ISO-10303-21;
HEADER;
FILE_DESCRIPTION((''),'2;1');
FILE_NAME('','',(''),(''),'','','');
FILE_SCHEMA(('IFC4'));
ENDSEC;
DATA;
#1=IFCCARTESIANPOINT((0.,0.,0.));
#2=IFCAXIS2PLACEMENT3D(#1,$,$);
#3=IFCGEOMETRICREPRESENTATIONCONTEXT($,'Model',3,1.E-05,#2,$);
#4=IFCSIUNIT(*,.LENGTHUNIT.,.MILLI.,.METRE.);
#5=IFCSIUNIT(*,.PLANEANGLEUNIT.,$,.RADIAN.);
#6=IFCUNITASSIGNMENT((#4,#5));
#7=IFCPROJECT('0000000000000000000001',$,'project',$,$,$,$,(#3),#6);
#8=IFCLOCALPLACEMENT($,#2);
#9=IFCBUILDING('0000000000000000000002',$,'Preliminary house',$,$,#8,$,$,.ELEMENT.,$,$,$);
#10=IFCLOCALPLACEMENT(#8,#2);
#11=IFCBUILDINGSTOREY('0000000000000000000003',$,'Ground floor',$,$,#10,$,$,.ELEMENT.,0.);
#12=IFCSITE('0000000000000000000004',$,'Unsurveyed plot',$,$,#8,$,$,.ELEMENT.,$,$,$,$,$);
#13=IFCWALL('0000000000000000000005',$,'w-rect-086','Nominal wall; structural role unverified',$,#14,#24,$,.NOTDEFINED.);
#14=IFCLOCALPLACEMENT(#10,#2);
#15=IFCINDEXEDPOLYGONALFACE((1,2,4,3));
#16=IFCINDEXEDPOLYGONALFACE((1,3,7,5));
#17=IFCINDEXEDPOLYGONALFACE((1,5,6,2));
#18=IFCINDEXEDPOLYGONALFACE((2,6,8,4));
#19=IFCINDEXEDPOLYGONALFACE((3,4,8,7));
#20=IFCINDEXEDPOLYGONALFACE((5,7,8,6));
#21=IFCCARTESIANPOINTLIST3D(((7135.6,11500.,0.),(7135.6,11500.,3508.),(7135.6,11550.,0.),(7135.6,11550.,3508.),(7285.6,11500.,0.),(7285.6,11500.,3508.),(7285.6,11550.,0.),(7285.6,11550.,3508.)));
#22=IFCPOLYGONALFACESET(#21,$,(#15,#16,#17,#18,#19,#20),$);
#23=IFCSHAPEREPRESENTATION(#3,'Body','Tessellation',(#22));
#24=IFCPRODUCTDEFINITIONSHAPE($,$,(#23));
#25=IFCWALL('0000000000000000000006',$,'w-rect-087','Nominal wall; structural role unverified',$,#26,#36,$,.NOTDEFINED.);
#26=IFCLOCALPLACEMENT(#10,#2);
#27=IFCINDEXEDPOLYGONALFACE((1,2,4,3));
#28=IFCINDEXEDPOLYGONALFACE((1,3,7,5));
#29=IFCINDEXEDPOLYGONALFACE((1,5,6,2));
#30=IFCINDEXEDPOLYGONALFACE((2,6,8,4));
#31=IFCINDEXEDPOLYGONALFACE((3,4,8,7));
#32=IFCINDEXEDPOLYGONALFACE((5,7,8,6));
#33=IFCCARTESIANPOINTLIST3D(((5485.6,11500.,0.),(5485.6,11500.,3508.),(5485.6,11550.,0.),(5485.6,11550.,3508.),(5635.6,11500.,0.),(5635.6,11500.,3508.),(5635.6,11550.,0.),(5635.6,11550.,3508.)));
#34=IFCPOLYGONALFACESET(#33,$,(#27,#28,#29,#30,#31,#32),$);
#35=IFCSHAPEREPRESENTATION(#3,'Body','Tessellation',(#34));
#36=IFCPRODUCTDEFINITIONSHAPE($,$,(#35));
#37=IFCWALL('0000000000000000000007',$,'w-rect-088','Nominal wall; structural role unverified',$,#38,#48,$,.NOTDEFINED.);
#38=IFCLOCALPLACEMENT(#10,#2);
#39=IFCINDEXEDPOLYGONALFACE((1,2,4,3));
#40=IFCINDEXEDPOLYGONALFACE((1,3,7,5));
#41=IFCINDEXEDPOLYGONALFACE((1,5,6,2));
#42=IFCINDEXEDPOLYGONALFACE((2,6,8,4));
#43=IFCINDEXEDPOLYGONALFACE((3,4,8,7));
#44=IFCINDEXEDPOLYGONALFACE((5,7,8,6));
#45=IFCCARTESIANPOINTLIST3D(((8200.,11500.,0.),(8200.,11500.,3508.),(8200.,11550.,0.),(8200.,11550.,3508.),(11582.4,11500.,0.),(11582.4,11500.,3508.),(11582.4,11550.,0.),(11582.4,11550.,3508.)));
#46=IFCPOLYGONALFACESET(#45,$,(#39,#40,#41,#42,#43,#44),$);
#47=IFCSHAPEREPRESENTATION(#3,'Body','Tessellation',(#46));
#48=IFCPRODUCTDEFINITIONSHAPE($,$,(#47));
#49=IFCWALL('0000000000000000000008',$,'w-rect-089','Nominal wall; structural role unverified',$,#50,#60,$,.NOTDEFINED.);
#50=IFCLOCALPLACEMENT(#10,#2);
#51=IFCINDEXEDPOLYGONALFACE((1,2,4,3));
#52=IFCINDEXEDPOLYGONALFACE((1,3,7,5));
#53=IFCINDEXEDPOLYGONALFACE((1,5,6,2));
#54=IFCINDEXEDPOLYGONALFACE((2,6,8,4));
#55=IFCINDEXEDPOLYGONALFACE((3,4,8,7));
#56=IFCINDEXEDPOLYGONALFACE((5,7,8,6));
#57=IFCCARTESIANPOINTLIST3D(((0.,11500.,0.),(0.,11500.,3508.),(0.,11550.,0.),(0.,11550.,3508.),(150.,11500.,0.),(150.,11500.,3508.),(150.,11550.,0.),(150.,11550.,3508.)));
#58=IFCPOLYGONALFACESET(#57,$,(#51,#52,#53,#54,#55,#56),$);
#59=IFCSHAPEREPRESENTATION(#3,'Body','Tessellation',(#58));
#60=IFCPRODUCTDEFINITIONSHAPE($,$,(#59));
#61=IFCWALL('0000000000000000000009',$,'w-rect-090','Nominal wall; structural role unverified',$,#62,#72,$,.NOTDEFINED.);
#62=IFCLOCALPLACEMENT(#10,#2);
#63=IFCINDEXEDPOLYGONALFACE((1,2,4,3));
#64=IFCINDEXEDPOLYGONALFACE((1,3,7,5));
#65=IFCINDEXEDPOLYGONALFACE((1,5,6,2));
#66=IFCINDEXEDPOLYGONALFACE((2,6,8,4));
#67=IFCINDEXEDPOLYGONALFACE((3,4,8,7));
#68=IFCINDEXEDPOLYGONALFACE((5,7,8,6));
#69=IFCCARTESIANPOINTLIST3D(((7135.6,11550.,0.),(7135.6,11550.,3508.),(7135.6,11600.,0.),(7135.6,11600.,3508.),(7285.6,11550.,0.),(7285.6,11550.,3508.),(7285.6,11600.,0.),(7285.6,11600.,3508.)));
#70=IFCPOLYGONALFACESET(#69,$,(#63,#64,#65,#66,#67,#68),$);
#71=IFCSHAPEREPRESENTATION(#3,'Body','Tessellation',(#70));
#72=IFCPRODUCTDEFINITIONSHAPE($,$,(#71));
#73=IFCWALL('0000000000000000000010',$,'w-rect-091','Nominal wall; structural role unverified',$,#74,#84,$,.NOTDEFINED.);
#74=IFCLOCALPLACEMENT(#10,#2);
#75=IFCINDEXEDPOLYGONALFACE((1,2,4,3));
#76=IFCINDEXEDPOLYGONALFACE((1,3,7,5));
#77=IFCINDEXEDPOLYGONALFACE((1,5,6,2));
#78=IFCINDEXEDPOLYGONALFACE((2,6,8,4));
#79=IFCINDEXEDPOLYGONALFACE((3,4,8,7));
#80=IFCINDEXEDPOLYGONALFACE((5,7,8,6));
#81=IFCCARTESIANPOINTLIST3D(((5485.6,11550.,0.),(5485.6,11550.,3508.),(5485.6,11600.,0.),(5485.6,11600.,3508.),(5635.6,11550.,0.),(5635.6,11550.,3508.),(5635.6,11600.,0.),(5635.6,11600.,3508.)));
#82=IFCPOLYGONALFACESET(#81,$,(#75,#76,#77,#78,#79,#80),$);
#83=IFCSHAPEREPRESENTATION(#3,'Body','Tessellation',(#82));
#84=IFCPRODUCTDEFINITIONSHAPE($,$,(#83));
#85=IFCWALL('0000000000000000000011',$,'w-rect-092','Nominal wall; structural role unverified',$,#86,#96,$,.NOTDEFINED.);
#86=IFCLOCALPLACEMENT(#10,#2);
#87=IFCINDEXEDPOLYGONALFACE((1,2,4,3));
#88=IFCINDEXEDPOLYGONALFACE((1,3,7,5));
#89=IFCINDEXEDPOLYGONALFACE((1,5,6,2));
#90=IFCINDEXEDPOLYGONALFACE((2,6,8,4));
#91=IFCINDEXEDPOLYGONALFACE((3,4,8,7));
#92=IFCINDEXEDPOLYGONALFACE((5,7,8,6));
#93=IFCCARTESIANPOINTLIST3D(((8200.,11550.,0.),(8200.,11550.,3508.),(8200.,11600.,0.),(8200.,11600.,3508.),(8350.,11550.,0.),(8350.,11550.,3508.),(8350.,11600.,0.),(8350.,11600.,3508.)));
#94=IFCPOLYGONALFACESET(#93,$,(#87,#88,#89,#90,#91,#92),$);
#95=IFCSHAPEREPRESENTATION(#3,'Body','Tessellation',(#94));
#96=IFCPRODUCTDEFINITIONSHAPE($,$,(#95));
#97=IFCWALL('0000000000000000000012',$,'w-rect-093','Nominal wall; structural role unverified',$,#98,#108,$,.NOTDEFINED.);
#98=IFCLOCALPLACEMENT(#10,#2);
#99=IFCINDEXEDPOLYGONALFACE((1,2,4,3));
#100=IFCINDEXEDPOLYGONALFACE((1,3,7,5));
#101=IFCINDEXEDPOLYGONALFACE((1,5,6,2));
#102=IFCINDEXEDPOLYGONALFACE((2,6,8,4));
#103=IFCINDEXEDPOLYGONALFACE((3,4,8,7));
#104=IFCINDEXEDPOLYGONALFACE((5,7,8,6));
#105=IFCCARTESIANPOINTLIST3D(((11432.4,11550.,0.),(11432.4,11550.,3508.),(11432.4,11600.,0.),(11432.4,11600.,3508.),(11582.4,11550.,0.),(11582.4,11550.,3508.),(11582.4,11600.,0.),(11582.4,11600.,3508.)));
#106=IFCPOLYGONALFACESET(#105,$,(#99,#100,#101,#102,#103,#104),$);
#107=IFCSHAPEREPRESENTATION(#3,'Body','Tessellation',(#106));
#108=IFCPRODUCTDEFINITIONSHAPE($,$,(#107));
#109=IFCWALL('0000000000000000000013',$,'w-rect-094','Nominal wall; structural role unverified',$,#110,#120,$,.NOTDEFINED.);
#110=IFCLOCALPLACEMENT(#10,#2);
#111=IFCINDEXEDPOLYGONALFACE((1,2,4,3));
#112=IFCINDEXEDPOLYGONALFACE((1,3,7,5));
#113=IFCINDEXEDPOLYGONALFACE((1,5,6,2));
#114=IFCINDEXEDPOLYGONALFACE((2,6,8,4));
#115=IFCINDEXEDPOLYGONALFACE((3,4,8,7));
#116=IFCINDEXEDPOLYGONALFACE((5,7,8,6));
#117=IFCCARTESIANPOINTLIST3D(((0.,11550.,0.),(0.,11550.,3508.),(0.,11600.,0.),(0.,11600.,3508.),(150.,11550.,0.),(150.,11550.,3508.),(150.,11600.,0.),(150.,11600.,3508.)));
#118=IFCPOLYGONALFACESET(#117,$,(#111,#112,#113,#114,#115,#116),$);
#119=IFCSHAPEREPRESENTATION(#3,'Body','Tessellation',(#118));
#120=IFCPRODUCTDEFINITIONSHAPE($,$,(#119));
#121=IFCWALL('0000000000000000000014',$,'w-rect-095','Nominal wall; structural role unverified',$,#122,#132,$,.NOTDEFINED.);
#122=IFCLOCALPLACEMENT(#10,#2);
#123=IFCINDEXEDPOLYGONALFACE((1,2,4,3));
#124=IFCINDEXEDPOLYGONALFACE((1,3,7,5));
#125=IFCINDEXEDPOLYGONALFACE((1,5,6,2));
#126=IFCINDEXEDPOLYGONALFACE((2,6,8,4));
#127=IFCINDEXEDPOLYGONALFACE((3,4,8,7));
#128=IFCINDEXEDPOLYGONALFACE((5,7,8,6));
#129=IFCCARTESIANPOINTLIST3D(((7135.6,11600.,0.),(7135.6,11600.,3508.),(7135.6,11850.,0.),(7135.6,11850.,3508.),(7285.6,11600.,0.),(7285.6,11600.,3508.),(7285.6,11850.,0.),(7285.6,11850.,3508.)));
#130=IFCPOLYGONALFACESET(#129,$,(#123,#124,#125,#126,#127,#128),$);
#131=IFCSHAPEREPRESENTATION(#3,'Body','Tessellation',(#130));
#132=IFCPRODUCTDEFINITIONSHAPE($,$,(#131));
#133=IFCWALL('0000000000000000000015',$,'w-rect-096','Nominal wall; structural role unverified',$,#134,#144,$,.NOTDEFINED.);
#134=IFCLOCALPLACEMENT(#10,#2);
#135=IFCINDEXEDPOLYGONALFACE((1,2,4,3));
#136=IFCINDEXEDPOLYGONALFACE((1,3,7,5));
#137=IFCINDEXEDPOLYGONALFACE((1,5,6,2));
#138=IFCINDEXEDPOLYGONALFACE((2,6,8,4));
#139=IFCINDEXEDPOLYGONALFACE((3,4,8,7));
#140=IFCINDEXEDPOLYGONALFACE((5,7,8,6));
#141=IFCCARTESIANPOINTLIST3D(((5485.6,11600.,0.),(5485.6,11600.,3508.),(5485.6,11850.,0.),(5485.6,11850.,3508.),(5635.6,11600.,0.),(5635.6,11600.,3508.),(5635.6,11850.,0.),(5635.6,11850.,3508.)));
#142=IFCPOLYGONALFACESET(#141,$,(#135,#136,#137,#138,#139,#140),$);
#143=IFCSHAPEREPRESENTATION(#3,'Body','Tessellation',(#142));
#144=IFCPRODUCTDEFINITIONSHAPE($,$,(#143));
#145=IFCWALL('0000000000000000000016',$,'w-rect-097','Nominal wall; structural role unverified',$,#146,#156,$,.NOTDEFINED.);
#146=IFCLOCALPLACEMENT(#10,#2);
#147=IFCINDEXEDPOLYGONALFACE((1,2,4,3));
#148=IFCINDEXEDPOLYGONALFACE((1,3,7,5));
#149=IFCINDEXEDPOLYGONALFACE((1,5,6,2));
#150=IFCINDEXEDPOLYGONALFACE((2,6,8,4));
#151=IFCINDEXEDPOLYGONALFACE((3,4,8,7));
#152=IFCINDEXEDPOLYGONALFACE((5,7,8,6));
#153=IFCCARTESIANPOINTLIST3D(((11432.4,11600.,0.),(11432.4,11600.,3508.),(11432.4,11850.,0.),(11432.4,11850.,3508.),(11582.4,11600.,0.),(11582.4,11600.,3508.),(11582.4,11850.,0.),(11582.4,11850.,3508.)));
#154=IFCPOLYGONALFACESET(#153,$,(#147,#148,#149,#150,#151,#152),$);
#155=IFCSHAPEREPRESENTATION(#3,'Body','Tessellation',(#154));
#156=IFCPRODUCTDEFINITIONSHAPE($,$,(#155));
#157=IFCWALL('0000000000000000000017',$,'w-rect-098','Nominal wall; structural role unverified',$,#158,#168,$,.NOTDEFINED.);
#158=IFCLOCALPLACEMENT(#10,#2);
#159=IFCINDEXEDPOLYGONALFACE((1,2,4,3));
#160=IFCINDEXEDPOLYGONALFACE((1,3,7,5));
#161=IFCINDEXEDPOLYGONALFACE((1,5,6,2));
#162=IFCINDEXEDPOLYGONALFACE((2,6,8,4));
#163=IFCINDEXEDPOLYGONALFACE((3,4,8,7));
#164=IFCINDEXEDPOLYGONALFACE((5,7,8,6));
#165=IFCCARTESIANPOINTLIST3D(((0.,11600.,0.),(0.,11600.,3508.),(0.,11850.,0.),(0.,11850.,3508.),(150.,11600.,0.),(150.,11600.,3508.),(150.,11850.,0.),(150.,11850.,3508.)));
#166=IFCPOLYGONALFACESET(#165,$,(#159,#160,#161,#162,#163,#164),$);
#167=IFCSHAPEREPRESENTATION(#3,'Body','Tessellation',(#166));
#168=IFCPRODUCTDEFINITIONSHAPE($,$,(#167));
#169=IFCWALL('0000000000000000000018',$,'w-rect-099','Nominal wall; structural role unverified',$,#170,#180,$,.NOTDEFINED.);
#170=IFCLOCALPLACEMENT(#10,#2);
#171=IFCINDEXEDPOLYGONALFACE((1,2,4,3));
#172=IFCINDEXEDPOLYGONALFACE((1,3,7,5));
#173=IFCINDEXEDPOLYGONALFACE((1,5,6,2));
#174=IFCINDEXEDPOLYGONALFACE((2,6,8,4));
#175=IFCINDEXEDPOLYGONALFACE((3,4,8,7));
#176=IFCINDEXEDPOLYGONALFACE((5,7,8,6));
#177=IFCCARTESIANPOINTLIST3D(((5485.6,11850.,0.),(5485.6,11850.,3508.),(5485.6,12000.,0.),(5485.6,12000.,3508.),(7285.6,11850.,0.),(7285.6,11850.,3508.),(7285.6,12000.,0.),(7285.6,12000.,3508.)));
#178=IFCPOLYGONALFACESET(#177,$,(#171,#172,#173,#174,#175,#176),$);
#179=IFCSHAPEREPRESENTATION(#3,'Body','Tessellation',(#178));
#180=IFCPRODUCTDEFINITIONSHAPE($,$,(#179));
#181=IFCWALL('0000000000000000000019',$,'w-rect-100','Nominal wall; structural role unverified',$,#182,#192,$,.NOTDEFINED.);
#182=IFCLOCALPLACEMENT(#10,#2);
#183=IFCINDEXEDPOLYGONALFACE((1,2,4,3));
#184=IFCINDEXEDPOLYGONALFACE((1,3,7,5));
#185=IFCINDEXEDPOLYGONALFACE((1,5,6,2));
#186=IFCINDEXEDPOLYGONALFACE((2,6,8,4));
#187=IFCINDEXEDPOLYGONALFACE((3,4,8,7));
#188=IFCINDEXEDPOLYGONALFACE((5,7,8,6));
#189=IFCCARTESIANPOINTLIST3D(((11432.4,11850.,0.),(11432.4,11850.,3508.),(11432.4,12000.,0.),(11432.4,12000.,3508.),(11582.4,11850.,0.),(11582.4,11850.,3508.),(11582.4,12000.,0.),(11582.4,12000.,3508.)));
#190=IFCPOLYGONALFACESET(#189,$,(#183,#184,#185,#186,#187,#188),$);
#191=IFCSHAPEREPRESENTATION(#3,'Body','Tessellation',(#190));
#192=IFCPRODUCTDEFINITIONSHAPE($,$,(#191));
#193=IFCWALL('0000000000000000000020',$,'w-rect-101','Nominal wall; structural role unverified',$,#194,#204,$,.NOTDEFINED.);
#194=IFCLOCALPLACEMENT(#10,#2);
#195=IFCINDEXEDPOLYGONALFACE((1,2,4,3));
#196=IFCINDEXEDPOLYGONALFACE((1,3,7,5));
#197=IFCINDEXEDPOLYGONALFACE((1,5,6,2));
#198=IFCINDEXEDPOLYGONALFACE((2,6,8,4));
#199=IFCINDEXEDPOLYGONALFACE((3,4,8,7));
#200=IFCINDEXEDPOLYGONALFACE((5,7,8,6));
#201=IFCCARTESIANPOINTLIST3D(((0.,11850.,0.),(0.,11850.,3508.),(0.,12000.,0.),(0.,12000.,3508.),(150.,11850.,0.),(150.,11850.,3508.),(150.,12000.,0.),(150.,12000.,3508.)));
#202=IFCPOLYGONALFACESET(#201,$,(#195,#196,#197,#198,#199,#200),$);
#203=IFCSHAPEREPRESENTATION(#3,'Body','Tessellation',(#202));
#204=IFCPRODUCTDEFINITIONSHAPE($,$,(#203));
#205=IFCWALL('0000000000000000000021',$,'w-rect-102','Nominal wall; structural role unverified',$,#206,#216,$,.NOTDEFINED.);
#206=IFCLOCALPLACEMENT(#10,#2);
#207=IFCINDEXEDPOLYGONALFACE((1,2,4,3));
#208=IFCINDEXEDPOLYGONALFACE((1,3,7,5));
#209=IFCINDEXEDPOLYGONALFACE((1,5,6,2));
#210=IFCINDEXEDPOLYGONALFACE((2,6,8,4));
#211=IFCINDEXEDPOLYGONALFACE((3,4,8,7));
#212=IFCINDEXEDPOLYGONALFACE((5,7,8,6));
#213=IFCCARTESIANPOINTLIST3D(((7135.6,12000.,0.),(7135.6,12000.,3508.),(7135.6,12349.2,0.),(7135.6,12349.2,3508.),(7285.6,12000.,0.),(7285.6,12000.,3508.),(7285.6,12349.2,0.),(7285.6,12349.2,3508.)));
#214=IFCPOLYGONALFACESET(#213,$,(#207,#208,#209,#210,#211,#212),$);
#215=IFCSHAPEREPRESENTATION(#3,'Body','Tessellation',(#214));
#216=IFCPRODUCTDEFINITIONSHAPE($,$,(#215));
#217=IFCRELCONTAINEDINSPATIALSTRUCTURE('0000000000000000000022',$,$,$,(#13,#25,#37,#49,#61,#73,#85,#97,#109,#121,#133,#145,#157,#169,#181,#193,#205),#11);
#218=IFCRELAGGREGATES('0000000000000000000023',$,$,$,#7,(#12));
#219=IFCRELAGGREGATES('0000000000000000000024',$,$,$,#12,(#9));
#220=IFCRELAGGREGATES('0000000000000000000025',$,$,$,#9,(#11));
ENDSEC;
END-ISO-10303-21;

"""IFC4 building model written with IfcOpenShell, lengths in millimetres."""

from ifc_helpers import new_model, si_unit, origin, place, context, project, spatial, polyline, outline, extrude, element, save


model = new_model("IFC4")

# Units and contexts
model_context = context("Model", 3, precision=1e-05, world=origin())
ifc_project = project(units=[si_unit("LENGTHUNIT", "METRE", prefix="MILLI"), si_unit("PLANEANGLEUNIT", "RADIAN")], contexts=[model_context])

# Site, building, storey
placement_1 = place(None, origin())
site = spatial("IfcSite", under=ifc_project, at=placement_1, Name="Unsurveyed plot", CompositionType="ELEMENT")
building = spatial("IfcBuilding", under=site, at=placement_1, Name="Preliminary house", CompositionType="ELEMENT")
placement_2 = place(placement_1, origin())
storey = spatial("IfcBuildingStorey", under=building, at=placement_2, Name="Ground floor", CompositionType="ELEMENT", Elevation=0.0)

# Walls
element("IfcWall", 1, at=placement_2, inside=storey, Name="w-rect-086", Description="Nominal wall; structural role unverified", PredefinedType="NOTDEFINED", context=model_context, shape_type="SweptSolid", body=[
    extrude(outline(polyline([(7135.6, 11500.0), (7285.6, 11500.0), (7285.6, 11550.0), (7135.6, 11550.0), (7135.6, 11500.0)])), origin(), (0.0, 0.0, 1.0), 3508.0),
])
element("IfcWall", 2, at=placement_2, inside=storey, Name="w-rect-087", Description="Nominal wall; structural role unverified", PredefinedType="NOTDEFINED", context=model_context, shape_type="SweptSolid", body=[
    extrude(outline(polyline([(5485.6, 11500.0), (5635.6, 11500.0), (5635.6, 11550.0), (5485.6, 11550.0), (5485.6, 11500.0)])), origin(), (0.0, 0.0, 1.0), 3508.0),
])
element("IfcWall", 3, at=placement_2, inside=storey, Name="w-rect-088", Description="Nominal wall; structural role unverified", PredefinedType="NOTDEFINED", context=model_context, shape_type="SweptSolid", body=[
    extrude(outline(polyline([(8200.0, 11500.0), (11582.4, 11500.0), (11582.4, 11550.0), (8200.0, 11550.0), (8200.0, 11500.0)])), origin(), (0.0, 0.0, 1.0), 3508.0),
])
element("IfcWall", 4, at=placement_2, inside=storey, Name="w-rect-089", Description="Nominal wall; structural role unverified", PredefinedType="NOTDEFINED", context=model_context, shape_type="SweptSolid", body=[
    extrude(outline(polyline([(0.0, 11500.0), (150.0, 11500.0), (150.0, 11550.0), (0.0, 11550.0), (0.0, 11500.0)])), origin(), (0.0, 0.0, 1.0), 3508.0),
])
element("IfcWall", 5, at=placement_2, inside=storey, Name="w-rect-090", Description="Nominal wall; structural role unverified", PredefinedType="NOTDEFINED", context=model_context, shape_type="SweptSolid", body=[
    extrude(outline(polyline([(7135.6, 11550.0), (7285.6, 11550.0), (7285.6, 11600.0), (7135.6, 11600.0), (7135.6, 11550.0)])), origin(), (0.0, 0.0, 1.0), 3508.0),
])
element("IfcWall", 6, at=placement_2, inside=storey, Name="w-rect-091", Description="Nominal wall; structural role unverified", PredefinedType="NOTDEFINED", context=model_context, shape_type="SweptSolid", body=[
    extrude(outline(polyline([(5485.6, 11550.0), (5635.6, 11550.0), (5635.6, 11600.0), (5485.6, 11600.0), (5485.6, 11550.0)])), origin(), (0.0, 0.0, 1.0), 3508.0),
])
element("IfcWall", 7, at=placement_2, inside=storey, Name="w-rect-092", Description="Nominal wall; structural role unverified", PredefinedType="NOTDEFINED", context=model_context, shape_type="SweptSolid", body=[
    extrude(outline(polyline([(8200.0, 11550.0), (8350.0, 11550.0), (8350.0, 11600.0), (8200.0, 11600.0), (8200.0, 11550.0)])), origin(), (0.0, 0.0, 1.0), 3508.0),
])
element("IfcWall", 8, at=placement_2, inside=storey, Name="w-rect-093", Description="Nominal wall; structural role unverified", PredefinedType="NOTDEFINED", context=model_context, shape_type="SweptSolid", body=[
    extrude(outline(polyline([(11432.4, 11550.0), (11582.4, 11550.0), (11582.4, 11600.0), (11432.4, 11600.0), (11432.4, 11550.0)])), origin(), (0.0, 0.0, 1.0), 3508.0),
])
element("IfcWall", 9, at=placement_2, inside=storey, Name="w-rect-094", Description="Nominal wall; structural role unverified", PredefinedType="NOTDEFINED", context=model_context, shape_type="SweptSolid", body=[
    extrude(outline(polyline([(0.0, 11550.0), (150.0, 11550.0), (150.0, 11600.0), (0.0, 11600.0), (0.0, 11550.0)])), origin(), (0.0, 0.0, 1.0), 3508.0),
])
element("IfcWall", 10, at=placement_2, inside=storey, Name="w-rect-095", Description="Nominal wall; structural role unverified", PredefinedType="NOTDEFINED", context=model_context, shape_type="SweptSolid", body=[
    extrude(outline(polyline([(7135.6, 11600.0), (7285.6, 11600.0), (7285.6, 11850.0), (7135.6, 11850.0), (7135.6, 11600.0)])), origin(), (0.0, 0.0, 1.0), 3508.0),
])
element("IfcWall", 11, at=placement_2, inside=storey, Name="w-rect-096", Description="Nominal wall; structural role unverified", PredefinedType="NOTDEFINED", context=model_context, shape_type="SweptSolid", body=[
    extrude(outline(polyline([(5485.6, 11600.0), (5635.6, 11600.0), (5635.6, 11850.0), (5485.6, 11850.0), (5485.6, 11600.0)])), origin(), (0.0, 0.0, 1.0), 3508.0),
])
element("IfcWall", 12, at=placement_2, inside=storey, Name="w-rect-097", Description="Nominal wall; structural role unverified", PredefinedType="NOTDEFINED", context=model_context, shape_type="SweptSolid", body=[
    extrude(outline(polyline([(11432.4, 11600.0), (11582.4, 11600.0), (11582.4, 11850.0), (11432.4, 11850.0), (11432.4, 11600.0)])), origin(), (0.0, 0.0, 1.0), 3508.0),
])
element("IfcWall", 13, at=placement_2, inside=storey, Name="w-rect-098", Description="Nominal wall; structural role unverified", PredefinedType="NOTDEFINED", context=model_context, shape_type="SweptSolid", body=[
    extrude(outline(polyline([(0.0, 11600.0), (150.0, 11600.0), (150.0, 11850.0), (0.0, 11850.0), (0.0, 11600.0)])), origin(), (0.0, 0.0, 1.0), 3508.0),
])
element("IfcWall", 14, at=placement_2, inside=storey, Name="w-rect-099", Description="Nominal wall; structural role unverified", PredefinedType="NOTDEFINED", context=model_context, shape_type="SweptSolid", body=[
    extrude(outline(polyline([(5485.6, 11850.0), (7285.6, 11850.0), (7285.6, 12000.0), (5485.6, 12000.0), (5485.6, 11850.0)])), origin(), (0.0, 0.0, 1.0), 3508.0),
])
element("IfcWall", 15, at=placement_2, inside=storey, Name="w-rect-100", Description="Nominal wall; structural role unverified", PredefinedType="NOTDEFINED", context=model_context, shape_type="SweptSolid", body=[
    extrude(outline(polyline([(11432.4, 11850.0), (11582.4, 11850.0), (11582.4, 12000.0), (11432.4, 12000.0), (11432.4, 11850.0)])), origin(), (0.0, 0.0, 1.0), 3508.0),
])
element("IfcWall", 16, at=placement_2, inside=storey, Name="w-rect-101", Description="Nominal wall; structural role unverified", PredefinedType="NOTDEFINED", context=model_context, shape_type="SweptSolid", body=[
    extrude(outline(polyline([(0.0, 11850.0), (150.0, 11850.0), (150.0, 12000.0), (0.0, 12000.0), (0.0, 11850.0)])), origin(), (0.0, 0.0, 1.0), 3508.0),
])
element("IfcWall", 17, at=placement_2, inside=storey, Name="w-rect-102", Description="Nominal wall; structural role unverified", PredefinedType="NOTDEFINED", context=model_context, shape_type="SweptSolid", body=[
    extrude(outline(polyline([(7135.6, 12000.0), (7285.6, 12000.0), (7285.6, 12349.2), (7135.6, 12349.2), (7135.6, 12000.0)])), origin(), (0.0, 0.0, 1.0), 3508.0),
])

save(model, "model.ifc")
